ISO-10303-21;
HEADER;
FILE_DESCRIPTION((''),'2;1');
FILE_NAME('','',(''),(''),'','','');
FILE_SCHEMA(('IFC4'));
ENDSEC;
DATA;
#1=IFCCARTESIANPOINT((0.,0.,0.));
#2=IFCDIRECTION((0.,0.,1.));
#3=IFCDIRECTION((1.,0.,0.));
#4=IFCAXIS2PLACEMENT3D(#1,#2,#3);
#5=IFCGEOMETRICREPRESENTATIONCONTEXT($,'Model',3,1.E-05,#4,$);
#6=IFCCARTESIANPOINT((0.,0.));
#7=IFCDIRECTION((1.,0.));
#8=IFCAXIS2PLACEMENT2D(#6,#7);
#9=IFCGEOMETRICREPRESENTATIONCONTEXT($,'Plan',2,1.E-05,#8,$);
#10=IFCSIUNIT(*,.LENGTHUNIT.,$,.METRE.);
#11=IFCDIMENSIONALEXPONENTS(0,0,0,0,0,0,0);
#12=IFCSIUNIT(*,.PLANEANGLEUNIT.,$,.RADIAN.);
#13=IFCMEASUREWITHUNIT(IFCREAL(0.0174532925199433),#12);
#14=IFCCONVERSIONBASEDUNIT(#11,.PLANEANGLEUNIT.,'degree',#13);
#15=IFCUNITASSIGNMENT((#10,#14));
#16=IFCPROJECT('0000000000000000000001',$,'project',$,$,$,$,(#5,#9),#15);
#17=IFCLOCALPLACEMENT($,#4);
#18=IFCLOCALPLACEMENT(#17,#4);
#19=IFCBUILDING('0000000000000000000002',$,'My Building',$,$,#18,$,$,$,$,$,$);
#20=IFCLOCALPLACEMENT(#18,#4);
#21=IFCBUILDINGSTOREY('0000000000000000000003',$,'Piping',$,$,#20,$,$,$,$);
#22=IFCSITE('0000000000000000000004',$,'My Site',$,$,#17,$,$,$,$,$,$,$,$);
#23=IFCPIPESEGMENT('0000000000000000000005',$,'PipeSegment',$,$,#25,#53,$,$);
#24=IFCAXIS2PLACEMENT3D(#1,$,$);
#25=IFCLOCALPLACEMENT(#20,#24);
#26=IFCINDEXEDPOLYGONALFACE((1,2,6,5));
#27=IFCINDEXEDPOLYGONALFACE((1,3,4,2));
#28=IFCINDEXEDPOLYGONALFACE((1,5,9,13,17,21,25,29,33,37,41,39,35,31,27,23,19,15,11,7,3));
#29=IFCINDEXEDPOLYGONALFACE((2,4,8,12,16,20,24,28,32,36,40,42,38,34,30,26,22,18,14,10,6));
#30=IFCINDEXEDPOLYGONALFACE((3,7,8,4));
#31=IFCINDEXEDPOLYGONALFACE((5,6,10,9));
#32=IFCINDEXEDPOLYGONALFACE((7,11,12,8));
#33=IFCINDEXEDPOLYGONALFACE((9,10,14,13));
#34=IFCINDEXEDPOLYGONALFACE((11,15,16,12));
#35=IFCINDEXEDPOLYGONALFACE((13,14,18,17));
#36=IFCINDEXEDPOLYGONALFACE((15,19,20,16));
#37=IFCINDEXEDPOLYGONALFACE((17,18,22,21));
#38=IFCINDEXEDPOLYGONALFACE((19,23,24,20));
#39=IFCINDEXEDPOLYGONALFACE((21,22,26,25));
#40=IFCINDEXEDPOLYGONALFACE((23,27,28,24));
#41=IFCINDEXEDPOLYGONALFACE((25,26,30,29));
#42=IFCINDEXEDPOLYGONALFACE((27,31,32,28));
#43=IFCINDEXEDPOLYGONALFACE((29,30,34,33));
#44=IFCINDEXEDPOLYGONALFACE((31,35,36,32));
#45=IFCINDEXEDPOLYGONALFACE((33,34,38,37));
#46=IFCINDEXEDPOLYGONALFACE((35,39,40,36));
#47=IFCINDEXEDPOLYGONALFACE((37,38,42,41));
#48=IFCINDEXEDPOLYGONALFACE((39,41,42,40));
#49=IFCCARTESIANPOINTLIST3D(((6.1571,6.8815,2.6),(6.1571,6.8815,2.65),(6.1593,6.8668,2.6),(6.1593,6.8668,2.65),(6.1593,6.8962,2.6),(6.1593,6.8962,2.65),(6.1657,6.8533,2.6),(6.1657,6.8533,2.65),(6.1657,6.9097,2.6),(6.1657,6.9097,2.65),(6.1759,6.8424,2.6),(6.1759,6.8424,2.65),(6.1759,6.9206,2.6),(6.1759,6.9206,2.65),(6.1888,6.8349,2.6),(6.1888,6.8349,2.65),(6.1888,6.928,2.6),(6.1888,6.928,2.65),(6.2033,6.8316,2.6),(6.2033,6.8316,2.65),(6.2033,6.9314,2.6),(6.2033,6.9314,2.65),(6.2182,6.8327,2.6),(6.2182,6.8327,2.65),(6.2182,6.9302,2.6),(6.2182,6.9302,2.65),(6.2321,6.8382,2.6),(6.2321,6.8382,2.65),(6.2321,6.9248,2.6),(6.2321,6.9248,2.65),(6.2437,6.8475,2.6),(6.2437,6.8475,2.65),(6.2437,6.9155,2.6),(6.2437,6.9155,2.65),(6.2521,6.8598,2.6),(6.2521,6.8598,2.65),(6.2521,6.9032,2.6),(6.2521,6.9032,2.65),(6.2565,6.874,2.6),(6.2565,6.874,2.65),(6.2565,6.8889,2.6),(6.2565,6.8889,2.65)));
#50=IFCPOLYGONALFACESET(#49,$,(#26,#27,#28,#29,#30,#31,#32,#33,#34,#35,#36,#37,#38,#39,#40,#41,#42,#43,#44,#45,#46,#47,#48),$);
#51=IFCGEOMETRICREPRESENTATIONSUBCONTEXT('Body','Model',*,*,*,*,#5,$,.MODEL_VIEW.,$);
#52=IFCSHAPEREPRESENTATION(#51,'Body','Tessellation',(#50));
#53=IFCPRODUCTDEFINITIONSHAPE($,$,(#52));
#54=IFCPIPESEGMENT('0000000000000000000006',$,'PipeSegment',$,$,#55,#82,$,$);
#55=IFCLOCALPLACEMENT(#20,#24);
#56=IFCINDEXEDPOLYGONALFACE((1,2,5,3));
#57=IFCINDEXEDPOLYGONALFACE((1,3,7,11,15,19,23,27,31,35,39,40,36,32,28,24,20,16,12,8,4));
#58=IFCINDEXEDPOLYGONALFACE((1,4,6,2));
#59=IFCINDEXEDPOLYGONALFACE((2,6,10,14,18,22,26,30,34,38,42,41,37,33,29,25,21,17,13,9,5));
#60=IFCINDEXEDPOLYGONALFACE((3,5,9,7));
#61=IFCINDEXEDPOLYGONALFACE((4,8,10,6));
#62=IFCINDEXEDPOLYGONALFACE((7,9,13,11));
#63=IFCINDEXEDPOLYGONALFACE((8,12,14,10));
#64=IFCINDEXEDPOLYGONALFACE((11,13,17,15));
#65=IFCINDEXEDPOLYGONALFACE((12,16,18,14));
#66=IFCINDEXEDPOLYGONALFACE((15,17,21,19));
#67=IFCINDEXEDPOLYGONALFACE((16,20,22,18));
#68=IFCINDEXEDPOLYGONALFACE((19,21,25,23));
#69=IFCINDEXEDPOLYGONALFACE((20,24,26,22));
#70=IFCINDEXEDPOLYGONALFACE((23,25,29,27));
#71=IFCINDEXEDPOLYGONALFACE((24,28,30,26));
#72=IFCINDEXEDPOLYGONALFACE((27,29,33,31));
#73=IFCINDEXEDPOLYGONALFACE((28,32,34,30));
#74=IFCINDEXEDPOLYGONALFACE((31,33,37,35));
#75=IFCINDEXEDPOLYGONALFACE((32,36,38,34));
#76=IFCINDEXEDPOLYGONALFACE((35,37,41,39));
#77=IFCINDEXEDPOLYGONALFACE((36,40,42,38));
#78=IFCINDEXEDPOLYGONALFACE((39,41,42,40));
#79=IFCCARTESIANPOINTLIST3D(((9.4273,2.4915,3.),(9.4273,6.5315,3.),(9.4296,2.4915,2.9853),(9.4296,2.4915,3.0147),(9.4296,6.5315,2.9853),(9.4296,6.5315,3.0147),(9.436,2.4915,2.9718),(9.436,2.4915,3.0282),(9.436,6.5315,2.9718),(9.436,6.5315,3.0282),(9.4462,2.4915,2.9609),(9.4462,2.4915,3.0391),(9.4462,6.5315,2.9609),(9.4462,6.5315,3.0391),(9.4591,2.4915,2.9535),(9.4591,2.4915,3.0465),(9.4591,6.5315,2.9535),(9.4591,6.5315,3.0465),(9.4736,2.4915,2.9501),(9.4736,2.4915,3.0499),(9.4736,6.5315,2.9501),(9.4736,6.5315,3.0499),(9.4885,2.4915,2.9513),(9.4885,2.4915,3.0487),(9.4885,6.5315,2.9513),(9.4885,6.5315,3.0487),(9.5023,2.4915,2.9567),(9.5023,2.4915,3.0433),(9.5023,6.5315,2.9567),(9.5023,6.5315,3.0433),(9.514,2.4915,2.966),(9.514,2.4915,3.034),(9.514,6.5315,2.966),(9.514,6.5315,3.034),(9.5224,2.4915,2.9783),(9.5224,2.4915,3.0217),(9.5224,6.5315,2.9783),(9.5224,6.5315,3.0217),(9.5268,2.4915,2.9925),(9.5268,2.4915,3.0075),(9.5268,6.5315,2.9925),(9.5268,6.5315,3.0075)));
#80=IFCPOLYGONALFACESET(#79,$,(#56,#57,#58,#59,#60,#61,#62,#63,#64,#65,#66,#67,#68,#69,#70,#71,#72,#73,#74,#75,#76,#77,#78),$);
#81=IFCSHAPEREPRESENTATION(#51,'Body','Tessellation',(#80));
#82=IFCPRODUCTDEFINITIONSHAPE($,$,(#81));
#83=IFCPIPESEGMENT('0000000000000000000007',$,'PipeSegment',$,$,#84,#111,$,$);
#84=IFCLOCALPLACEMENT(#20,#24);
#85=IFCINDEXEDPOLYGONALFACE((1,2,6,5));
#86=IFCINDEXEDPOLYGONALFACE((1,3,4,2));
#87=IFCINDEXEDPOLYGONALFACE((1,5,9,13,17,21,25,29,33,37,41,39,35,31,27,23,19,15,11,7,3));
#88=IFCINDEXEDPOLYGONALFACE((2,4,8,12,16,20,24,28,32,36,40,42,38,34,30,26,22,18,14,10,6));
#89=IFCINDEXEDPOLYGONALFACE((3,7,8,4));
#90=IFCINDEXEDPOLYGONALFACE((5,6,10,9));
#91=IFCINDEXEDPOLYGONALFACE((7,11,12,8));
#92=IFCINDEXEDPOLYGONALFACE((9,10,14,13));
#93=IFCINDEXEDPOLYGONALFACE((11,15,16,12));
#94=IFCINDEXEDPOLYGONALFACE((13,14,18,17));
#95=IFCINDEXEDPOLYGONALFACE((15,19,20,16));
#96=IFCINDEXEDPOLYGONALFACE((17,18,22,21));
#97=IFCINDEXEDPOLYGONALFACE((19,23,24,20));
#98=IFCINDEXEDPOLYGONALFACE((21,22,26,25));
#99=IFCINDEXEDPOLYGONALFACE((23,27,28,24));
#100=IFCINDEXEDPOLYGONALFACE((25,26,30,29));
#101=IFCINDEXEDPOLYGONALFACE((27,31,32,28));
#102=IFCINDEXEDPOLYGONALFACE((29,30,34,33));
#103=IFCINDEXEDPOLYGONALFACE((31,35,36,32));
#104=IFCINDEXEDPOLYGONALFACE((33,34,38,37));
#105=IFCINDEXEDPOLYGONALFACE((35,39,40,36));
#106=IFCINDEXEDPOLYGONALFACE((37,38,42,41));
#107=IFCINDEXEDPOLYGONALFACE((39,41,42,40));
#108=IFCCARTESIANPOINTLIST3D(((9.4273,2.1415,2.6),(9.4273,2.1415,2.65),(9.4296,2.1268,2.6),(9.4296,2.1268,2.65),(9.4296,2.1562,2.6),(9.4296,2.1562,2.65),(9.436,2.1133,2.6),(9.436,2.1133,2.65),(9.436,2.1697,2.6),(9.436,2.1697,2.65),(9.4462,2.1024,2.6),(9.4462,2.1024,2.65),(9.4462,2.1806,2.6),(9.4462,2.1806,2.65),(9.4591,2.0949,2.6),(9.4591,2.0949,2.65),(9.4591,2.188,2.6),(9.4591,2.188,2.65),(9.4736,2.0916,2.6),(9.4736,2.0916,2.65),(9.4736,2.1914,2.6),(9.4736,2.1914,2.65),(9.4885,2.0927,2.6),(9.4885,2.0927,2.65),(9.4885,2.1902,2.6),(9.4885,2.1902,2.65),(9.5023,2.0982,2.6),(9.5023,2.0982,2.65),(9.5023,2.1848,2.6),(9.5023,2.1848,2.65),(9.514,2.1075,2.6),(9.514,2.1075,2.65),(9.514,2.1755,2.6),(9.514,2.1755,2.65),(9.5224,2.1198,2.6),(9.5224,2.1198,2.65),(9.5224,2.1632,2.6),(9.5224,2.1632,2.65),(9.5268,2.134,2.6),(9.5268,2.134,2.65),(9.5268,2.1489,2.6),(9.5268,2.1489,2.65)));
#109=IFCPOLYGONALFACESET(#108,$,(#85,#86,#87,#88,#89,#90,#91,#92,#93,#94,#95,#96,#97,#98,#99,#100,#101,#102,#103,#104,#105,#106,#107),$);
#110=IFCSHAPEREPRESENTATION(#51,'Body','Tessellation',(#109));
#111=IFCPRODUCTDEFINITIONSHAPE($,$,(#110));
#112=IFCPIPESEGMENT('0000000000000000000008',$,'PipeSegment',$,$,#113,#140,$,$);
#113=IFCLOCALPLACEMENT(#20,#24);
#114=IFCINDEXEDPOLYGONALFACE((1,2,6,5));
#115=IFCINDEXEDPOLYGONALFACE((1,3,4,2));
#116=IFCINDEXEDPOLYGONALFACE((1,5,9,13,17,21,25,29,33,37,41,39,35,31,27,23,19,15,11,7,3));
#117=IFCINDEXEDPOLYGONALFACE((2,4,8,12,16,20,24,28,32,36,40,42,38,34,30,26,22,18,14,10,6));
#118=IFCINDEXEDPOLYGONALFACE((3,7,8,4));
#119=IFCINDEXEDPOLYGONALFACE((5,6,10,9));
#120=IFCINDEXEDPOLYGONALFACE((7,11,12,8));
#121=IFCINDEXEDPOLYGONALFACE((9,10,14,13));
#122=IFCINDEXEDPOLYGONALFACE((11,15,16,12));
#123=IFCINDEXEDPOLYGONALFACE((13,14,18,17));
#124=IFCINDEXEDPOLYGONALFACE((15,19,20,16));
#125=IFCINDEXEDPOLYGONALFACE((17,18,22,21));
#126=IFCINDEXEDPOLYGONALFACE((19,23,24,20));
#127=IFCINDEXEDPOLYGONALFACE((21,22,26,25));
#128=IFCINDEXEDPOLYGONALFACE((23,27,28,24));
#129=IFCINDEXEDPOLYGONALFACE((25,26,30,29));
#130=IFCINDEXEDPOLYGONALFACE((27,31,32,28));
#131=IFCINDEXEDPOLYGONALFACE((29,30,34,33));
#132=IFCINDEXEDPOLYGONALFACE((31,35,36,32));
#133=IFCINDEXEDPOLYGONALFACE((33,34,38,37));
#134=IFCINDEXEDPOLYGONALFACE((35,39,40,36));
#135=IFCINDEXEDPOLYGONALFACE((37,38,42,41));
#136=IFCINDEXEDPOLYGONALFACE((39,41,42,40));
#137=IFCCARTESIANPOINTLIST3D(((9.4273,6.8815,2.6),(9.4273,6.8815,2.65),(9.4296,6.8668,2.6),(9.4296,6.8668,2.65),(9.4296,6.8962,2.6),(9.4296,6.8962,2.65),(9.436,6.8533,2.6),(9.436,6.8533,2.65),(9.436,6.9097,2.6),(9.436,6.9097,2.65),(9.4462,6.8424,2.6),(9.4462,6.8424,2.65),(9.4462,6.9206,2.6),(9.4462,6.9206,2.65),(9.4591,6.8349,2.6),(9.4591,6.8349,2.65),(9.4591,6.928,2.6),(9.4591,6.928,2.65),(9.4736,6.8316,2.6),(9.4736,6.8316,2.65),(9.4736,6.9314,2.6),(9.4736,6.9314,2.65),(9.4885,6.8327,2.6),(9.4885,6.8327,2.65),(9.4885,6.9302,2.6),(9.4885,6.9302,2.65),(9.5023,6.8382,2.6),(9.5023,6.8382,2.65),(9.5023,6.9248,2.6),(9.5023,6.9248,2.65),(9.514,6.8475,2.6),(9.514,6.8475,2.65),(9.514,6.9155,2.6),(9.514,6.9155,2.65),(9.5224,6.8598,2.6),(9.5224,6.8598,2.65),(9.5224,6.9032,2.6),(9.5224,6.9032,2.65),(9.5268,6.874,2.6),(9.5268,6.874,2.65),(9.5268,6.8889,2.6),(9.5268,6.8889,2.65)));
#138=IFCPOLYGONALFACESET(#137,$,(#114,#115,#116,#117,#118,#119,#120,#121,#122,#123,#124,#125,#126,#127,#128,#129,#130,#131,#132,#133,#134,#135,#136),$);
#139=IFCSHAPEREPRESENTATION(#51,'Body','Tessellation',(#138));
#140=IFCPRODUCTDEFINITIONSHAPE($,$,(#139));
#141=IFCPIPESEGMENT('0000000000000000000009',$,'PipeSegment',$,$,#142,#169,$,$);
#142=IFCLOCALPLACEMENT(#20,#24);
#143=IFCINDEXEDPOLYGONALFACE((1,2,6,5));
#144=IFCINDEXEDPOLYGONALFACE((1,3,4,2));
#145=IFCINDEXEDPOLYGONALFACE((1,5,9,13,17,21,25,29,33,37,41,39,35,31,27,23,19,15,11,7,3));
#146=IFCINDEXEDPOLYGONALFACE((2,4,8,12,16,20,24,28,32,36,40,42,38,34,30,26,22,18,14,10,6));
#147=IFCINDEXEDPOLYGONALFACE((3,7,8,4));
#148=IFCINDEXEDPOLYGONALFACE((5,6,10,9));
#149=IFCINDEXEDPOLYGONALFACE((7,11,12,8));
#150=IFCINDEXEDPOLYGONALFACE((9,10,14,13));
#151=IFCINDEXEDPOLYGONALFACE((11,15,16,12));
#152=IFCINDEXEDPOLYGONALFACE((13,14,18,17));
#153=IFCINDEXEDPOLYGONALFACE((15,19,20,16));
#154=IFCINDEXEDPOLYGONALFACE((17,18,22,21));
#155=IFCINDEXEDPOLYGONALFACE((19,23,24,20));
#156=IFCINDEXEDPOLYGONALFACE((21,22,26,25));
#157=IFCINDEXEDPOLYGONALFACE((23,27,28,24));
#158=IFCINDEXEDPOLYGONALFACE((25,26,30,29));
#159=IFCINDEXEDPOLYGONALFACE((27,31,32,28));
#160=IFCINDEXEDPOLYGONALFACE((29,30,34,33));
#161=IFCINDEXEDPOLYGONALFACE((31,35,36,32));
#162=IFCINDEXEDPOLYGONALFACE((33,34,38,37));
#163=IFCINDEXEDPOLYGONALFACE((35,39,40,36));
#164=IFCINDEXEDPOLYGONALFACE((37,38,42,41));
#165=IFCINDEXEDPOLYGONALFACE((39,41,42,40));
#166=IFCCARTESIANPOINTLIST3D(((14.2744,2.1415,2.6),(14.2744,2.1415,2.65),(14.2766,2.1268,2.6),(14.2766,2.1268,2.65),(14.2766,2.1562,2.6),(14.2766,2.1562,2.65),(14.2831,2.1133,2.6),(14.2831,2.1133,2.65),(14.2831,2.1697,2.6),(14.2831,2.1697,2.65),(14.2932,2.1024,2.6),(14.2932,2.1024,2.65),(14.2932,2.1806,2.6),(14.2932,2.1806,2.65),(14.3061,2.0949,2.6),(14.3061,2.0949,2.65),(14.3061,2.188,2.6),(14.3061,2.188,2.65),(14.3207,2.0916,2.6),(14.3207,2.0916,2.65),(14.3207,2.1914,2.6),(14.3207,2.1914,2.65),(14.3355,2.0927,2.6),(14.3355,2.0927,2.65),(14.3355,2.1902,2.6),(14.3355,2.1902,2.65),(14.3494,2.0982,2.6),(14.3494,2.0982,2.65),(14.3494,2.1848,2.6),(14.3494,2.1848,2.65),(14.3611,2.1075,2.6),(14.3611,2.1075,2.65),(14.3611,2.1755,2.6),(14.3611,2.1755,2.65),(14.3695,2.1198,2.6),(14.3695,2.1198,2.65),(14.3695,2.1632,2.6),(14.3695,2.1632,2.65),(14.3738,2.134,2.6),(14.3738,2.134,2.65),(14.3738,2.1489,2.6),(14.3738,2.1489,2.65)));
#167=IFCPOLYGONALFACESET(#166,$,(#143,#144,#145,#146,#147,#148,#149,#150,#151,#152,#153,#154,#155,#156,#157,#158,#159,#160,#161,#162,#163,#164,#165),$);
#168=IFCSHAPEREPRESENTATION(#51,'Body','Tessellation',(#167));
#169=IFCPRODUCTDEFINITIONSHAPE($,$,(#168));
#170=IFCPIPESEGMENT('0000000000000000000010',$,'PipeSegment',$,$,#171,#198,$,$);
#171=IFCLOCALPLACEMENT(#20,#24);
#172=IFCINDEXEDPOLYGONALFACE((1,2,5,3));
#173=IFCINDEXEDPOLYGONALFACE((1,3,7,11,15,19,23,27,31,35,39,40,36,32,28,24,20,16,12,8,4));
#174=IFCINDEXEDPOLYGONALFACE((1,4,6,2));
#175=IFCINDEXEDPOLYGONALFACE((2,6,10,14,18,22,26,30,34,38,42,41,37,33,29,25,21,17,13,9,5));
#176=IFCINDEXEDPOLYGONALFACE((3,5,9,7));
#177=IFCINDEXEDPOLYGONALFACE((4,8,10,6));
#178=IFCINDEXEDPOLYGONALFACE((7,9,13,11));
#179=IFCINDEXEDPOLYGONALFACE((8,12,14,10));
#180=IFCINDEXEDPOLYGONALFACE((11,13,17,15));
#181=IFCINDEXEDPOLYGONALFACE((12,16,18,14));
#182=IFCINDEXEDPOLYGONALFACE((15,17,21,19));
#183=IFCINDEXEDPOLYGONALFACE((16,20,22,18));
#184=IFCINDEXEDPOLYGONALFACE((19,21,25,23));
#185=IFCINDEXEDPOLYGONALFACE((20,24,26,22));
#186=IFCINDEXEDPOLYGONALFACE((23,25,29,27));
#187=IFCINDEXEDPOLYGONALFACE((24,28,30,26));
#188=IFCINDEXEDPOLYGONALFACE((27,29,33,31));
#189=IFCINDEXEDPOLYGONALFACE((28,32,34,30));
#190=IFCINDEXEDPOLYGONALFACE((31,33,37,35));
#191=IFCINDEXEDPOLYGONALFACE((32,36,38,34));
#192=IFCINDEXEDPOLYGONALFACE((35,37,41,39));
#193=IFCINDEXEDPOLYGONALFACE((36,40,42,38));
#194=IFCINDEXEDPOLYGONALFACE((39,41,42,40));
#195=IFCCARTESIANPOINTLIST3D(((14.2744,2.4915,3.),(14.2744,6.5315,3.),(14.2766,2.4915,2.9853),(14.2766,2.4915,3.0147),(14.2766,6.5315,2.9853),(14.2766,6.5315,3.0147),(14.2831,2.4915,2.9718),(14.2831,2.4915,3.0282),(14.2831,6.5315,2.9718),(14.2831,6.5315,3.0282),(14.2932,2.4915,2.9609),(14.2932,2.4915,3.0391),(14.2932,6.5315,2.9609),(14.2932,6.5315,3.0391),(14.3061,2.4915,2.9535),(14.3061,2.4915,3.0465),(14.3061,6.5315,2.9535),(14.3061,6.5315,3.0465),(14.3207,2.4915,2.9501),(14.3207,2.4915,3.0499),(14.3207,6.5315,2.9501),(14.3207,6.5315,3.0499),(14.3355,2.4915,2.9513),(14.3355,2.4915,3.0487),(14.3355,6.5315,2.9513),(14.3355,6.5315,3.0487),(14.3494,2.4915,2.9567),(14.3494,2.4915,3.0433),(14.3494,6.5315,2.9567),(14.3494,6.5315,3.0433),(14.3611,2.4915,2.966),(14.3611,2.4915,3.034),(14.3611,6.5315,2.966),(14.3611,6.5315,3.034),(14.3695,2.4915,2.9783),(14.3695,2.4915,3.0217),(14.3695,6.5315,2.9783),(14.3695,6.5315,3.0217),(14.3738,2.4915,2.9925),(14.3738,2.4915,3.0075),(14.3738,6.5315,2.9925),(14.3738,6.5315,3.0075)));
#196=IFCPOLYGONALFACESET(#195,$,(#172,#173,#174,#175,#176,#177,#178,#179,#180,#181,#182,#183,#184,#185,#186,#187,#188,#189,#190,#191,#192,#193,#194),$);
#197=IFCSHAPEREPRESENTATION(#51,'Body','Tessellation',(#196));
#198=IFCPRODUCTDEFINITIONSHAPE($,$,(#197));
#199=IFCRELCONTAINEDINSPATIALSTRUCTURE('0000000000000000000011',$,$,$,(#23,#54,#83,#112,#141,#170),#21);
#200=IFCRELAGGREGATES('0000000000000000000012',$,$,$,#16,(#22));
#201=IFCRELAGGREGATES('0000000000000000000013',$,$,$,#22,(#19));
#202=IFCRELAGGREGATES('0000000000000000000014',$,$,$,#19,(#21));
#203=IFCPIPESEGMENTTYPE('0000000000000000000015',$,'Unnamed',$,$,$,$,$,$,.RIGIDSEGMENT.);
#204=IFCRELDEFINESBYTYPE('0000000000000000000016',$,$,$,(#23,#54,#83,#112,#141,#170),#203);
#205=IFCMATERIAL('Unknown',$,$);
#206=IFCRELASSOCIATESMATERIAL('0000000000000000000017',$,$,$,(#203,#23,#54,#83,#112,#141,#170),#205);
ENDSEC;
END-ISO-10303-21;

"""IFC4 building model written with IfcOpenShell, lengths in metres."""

from ifc_helpers import new_model, entity, si_unit, converted_unit, frame, origin_with_axes, origin_2d_with_axis, place, context, subcontext, project, spatial, circle, extrude, material, material_profile, profile_set, profile_usage, type_object, element, save


model = new_model("IFC4")

# Units and contexts
model_context = context("Model", 3, precision=1e-05, world=origin_with_axes())
plan_context = context("Plan", 2, precision=1e-05, world=origin_2d_with_axis())
body_context = subcontext(model_context, "Body", "Model", "MODEL_VIEW")
ifc_project = project(units=[si_unit("LENGTHUNIT", "METRE"), converted_unit("PLANEANGLEUNIT", "degree", entity("IfcReal", 0.0174532925199433), si_unit("PLANEANGLEUNIT", "RADIAN"), dimensions=[0, 0, 0, 0, 0, 0, 0])], contexts=[model_context, plan_context])

# Site, building, storey
site_placement = place(None, origin_with_axes())
site = spatial("IfcSite", under=ifc_project, at=site_placement, Name="My Site")
building_placement = place(site_placement, origin_with_axes())
building = spatial("IfcBuilding", under=site, at=building_placement, Name="My Building")
storey_placement = place(building_placement, origin_with_axes())
storey = spatial("IfcBuildingStorey", under=building, at=storey_placement, Name="Piping")

# Pipe segments
ifc_material = material(Name="Unknown")
ifc_material_profile_1 = material_profile(ifc_material, circle(Radius=0.05))
ifc_profile_set_1 = profile_set([ifc_material_profile_1])
pipe_segment_type = type_object("IfcPipeSegmentType", Name="Unnamed", PredefinedType="RIGIDSEGMENT", material=ifc_profile_set_1)
ifc_profile_usage_1 = profile_usage(ifc_profile_set_1, cardinal=5)
pipe_segment_1_placement = place(storey_placement, frame((6.2071, 6.8815, 2.65), z_axis=(0.0, 0.0, -1.0), x_axis=(-1.0, 0.0, 0.0)))
element("IfcPipeSegment", 1, at=pipe_segment_1_placement, inside=storey, type_object=pipe_segment_type, material=ifc_profile_usage_1, Name="PipeSegment", context=body_context, shape_type="SweptSolid", body=[
    extrude(circle(Radius=0.05), origin_with_axes(), (0.0, 0.0, 1.0), 0.05),
])
ifc_profile_usage_2 = profile_usage(ifc_profile_set_1, cardinal=5)
pipe_segment_2_placement = place(storey_placement, frame((9.4773, 2.4915, 3.0), z_axis=(0.0, 1.0, 0.0), x_axis=(-1.0, 0.0, 0.0)))
element("IfcPipeSegment", 2, at=pipe_segment_2_placement, inside=storey, type_object=pipe_segment_type, material=ifc_profile_usage_2, Name="PipeSegment", context=body_context, shape_type="SweptSolid", body=[
    extrude(circle(Radius=0.05), origin_with_axes(), (0.0, 0.0, 1.0), 4.04),
])
ifc_profile_usage_3 = profile_usage(ifc_profile_set_1, cardinal=5)
pipe_segment_3_placement = place(storey_placement, frame((9.4773, 2.1415, 2.65), z_axis=(0.0, 0.0, -1.0), x_axis=(-1.0, 0.0, 0.0)))
element("IfcPipeSegment", 3, at=pipe_segment_3_placement, inside=storey, type_object=pipe_segment_type, material=ifc_profile_usage_3, Name="PipeSegment", context=body_context, shape_type="SweptSolid", body=[
    extrude(circle(Radius=0.05), origin_with_axes(), (0.0, 0.0, 1.0), 0.05),
])
ifc_profile_usage_4 = profile_usage(ifc_profile_set_1, cardinal=5)
pipe_segment_4_placement = place(storey_placement, frame((9.4773, 6.8815, 2.65), z_axis=(0.0, 0.0, -1.0), x_axis=(-1.0, 0.0, 0.0)))
element("IfcPipeSegment", 4, at=pipe_segment_4_placement, inside=storey, type_object=pipe_segment_type, material=ifc_profile_usage_4, Name="PipeSegment", context=body_context, shape_type="SweptSolid", body=[
    extrude(circle(Radius=0.05), origin_with_axes(), (0.0, 0.0, 1.0), 0.05),
])
ifc_profile_usage_5 = profile_usage(ifc_profile_set_1, cardinal=5)
pipe_segment_5_placement = place(storey_placement, frame((14.3244, 2.1415, 2.65), z_axis=(0.0, 0.0, -1.0), x_axis=(-1.0, 0.0, 0.0)))
element("IfcPipeSegment", 5, at=pipe_segment_5_placement, inside=storey, type_object=pipe_segment_type, material=ifc_profile_usage_5, Name="PipeSegment", context=body_context, shape_type="SweptSolid", body=[
    extrude(circle(Radius=0.05), origin_with_axes(), (0.0, 0.0, 1.0), 0.05),
])
ifc_profile_usage_6 = profile_usage(ifc_profile_set_1, cardinal=5)
pipe_segment_6_placement = place(storey_placement, frame((14.3244, 2.4915, 3.0), z_axis=(0.0, 1.0, 0.0), x_axis=(-1.0, 0.0, 0.0)))
element("IfcPipeSegment", 6, at=pipe_segment_6_placement, inside=storey, type_object=pipe_segment_type, material=ifc_profile_usage_6, Name="PipeSegment", context=body_context, shape_type="SweptSolid", body=[
    extrude(circle(Radius=0.05), origin_with_axes(), (0.0, 0.0, 1.0), 4.04),
])

save(model, "model.ifc")
